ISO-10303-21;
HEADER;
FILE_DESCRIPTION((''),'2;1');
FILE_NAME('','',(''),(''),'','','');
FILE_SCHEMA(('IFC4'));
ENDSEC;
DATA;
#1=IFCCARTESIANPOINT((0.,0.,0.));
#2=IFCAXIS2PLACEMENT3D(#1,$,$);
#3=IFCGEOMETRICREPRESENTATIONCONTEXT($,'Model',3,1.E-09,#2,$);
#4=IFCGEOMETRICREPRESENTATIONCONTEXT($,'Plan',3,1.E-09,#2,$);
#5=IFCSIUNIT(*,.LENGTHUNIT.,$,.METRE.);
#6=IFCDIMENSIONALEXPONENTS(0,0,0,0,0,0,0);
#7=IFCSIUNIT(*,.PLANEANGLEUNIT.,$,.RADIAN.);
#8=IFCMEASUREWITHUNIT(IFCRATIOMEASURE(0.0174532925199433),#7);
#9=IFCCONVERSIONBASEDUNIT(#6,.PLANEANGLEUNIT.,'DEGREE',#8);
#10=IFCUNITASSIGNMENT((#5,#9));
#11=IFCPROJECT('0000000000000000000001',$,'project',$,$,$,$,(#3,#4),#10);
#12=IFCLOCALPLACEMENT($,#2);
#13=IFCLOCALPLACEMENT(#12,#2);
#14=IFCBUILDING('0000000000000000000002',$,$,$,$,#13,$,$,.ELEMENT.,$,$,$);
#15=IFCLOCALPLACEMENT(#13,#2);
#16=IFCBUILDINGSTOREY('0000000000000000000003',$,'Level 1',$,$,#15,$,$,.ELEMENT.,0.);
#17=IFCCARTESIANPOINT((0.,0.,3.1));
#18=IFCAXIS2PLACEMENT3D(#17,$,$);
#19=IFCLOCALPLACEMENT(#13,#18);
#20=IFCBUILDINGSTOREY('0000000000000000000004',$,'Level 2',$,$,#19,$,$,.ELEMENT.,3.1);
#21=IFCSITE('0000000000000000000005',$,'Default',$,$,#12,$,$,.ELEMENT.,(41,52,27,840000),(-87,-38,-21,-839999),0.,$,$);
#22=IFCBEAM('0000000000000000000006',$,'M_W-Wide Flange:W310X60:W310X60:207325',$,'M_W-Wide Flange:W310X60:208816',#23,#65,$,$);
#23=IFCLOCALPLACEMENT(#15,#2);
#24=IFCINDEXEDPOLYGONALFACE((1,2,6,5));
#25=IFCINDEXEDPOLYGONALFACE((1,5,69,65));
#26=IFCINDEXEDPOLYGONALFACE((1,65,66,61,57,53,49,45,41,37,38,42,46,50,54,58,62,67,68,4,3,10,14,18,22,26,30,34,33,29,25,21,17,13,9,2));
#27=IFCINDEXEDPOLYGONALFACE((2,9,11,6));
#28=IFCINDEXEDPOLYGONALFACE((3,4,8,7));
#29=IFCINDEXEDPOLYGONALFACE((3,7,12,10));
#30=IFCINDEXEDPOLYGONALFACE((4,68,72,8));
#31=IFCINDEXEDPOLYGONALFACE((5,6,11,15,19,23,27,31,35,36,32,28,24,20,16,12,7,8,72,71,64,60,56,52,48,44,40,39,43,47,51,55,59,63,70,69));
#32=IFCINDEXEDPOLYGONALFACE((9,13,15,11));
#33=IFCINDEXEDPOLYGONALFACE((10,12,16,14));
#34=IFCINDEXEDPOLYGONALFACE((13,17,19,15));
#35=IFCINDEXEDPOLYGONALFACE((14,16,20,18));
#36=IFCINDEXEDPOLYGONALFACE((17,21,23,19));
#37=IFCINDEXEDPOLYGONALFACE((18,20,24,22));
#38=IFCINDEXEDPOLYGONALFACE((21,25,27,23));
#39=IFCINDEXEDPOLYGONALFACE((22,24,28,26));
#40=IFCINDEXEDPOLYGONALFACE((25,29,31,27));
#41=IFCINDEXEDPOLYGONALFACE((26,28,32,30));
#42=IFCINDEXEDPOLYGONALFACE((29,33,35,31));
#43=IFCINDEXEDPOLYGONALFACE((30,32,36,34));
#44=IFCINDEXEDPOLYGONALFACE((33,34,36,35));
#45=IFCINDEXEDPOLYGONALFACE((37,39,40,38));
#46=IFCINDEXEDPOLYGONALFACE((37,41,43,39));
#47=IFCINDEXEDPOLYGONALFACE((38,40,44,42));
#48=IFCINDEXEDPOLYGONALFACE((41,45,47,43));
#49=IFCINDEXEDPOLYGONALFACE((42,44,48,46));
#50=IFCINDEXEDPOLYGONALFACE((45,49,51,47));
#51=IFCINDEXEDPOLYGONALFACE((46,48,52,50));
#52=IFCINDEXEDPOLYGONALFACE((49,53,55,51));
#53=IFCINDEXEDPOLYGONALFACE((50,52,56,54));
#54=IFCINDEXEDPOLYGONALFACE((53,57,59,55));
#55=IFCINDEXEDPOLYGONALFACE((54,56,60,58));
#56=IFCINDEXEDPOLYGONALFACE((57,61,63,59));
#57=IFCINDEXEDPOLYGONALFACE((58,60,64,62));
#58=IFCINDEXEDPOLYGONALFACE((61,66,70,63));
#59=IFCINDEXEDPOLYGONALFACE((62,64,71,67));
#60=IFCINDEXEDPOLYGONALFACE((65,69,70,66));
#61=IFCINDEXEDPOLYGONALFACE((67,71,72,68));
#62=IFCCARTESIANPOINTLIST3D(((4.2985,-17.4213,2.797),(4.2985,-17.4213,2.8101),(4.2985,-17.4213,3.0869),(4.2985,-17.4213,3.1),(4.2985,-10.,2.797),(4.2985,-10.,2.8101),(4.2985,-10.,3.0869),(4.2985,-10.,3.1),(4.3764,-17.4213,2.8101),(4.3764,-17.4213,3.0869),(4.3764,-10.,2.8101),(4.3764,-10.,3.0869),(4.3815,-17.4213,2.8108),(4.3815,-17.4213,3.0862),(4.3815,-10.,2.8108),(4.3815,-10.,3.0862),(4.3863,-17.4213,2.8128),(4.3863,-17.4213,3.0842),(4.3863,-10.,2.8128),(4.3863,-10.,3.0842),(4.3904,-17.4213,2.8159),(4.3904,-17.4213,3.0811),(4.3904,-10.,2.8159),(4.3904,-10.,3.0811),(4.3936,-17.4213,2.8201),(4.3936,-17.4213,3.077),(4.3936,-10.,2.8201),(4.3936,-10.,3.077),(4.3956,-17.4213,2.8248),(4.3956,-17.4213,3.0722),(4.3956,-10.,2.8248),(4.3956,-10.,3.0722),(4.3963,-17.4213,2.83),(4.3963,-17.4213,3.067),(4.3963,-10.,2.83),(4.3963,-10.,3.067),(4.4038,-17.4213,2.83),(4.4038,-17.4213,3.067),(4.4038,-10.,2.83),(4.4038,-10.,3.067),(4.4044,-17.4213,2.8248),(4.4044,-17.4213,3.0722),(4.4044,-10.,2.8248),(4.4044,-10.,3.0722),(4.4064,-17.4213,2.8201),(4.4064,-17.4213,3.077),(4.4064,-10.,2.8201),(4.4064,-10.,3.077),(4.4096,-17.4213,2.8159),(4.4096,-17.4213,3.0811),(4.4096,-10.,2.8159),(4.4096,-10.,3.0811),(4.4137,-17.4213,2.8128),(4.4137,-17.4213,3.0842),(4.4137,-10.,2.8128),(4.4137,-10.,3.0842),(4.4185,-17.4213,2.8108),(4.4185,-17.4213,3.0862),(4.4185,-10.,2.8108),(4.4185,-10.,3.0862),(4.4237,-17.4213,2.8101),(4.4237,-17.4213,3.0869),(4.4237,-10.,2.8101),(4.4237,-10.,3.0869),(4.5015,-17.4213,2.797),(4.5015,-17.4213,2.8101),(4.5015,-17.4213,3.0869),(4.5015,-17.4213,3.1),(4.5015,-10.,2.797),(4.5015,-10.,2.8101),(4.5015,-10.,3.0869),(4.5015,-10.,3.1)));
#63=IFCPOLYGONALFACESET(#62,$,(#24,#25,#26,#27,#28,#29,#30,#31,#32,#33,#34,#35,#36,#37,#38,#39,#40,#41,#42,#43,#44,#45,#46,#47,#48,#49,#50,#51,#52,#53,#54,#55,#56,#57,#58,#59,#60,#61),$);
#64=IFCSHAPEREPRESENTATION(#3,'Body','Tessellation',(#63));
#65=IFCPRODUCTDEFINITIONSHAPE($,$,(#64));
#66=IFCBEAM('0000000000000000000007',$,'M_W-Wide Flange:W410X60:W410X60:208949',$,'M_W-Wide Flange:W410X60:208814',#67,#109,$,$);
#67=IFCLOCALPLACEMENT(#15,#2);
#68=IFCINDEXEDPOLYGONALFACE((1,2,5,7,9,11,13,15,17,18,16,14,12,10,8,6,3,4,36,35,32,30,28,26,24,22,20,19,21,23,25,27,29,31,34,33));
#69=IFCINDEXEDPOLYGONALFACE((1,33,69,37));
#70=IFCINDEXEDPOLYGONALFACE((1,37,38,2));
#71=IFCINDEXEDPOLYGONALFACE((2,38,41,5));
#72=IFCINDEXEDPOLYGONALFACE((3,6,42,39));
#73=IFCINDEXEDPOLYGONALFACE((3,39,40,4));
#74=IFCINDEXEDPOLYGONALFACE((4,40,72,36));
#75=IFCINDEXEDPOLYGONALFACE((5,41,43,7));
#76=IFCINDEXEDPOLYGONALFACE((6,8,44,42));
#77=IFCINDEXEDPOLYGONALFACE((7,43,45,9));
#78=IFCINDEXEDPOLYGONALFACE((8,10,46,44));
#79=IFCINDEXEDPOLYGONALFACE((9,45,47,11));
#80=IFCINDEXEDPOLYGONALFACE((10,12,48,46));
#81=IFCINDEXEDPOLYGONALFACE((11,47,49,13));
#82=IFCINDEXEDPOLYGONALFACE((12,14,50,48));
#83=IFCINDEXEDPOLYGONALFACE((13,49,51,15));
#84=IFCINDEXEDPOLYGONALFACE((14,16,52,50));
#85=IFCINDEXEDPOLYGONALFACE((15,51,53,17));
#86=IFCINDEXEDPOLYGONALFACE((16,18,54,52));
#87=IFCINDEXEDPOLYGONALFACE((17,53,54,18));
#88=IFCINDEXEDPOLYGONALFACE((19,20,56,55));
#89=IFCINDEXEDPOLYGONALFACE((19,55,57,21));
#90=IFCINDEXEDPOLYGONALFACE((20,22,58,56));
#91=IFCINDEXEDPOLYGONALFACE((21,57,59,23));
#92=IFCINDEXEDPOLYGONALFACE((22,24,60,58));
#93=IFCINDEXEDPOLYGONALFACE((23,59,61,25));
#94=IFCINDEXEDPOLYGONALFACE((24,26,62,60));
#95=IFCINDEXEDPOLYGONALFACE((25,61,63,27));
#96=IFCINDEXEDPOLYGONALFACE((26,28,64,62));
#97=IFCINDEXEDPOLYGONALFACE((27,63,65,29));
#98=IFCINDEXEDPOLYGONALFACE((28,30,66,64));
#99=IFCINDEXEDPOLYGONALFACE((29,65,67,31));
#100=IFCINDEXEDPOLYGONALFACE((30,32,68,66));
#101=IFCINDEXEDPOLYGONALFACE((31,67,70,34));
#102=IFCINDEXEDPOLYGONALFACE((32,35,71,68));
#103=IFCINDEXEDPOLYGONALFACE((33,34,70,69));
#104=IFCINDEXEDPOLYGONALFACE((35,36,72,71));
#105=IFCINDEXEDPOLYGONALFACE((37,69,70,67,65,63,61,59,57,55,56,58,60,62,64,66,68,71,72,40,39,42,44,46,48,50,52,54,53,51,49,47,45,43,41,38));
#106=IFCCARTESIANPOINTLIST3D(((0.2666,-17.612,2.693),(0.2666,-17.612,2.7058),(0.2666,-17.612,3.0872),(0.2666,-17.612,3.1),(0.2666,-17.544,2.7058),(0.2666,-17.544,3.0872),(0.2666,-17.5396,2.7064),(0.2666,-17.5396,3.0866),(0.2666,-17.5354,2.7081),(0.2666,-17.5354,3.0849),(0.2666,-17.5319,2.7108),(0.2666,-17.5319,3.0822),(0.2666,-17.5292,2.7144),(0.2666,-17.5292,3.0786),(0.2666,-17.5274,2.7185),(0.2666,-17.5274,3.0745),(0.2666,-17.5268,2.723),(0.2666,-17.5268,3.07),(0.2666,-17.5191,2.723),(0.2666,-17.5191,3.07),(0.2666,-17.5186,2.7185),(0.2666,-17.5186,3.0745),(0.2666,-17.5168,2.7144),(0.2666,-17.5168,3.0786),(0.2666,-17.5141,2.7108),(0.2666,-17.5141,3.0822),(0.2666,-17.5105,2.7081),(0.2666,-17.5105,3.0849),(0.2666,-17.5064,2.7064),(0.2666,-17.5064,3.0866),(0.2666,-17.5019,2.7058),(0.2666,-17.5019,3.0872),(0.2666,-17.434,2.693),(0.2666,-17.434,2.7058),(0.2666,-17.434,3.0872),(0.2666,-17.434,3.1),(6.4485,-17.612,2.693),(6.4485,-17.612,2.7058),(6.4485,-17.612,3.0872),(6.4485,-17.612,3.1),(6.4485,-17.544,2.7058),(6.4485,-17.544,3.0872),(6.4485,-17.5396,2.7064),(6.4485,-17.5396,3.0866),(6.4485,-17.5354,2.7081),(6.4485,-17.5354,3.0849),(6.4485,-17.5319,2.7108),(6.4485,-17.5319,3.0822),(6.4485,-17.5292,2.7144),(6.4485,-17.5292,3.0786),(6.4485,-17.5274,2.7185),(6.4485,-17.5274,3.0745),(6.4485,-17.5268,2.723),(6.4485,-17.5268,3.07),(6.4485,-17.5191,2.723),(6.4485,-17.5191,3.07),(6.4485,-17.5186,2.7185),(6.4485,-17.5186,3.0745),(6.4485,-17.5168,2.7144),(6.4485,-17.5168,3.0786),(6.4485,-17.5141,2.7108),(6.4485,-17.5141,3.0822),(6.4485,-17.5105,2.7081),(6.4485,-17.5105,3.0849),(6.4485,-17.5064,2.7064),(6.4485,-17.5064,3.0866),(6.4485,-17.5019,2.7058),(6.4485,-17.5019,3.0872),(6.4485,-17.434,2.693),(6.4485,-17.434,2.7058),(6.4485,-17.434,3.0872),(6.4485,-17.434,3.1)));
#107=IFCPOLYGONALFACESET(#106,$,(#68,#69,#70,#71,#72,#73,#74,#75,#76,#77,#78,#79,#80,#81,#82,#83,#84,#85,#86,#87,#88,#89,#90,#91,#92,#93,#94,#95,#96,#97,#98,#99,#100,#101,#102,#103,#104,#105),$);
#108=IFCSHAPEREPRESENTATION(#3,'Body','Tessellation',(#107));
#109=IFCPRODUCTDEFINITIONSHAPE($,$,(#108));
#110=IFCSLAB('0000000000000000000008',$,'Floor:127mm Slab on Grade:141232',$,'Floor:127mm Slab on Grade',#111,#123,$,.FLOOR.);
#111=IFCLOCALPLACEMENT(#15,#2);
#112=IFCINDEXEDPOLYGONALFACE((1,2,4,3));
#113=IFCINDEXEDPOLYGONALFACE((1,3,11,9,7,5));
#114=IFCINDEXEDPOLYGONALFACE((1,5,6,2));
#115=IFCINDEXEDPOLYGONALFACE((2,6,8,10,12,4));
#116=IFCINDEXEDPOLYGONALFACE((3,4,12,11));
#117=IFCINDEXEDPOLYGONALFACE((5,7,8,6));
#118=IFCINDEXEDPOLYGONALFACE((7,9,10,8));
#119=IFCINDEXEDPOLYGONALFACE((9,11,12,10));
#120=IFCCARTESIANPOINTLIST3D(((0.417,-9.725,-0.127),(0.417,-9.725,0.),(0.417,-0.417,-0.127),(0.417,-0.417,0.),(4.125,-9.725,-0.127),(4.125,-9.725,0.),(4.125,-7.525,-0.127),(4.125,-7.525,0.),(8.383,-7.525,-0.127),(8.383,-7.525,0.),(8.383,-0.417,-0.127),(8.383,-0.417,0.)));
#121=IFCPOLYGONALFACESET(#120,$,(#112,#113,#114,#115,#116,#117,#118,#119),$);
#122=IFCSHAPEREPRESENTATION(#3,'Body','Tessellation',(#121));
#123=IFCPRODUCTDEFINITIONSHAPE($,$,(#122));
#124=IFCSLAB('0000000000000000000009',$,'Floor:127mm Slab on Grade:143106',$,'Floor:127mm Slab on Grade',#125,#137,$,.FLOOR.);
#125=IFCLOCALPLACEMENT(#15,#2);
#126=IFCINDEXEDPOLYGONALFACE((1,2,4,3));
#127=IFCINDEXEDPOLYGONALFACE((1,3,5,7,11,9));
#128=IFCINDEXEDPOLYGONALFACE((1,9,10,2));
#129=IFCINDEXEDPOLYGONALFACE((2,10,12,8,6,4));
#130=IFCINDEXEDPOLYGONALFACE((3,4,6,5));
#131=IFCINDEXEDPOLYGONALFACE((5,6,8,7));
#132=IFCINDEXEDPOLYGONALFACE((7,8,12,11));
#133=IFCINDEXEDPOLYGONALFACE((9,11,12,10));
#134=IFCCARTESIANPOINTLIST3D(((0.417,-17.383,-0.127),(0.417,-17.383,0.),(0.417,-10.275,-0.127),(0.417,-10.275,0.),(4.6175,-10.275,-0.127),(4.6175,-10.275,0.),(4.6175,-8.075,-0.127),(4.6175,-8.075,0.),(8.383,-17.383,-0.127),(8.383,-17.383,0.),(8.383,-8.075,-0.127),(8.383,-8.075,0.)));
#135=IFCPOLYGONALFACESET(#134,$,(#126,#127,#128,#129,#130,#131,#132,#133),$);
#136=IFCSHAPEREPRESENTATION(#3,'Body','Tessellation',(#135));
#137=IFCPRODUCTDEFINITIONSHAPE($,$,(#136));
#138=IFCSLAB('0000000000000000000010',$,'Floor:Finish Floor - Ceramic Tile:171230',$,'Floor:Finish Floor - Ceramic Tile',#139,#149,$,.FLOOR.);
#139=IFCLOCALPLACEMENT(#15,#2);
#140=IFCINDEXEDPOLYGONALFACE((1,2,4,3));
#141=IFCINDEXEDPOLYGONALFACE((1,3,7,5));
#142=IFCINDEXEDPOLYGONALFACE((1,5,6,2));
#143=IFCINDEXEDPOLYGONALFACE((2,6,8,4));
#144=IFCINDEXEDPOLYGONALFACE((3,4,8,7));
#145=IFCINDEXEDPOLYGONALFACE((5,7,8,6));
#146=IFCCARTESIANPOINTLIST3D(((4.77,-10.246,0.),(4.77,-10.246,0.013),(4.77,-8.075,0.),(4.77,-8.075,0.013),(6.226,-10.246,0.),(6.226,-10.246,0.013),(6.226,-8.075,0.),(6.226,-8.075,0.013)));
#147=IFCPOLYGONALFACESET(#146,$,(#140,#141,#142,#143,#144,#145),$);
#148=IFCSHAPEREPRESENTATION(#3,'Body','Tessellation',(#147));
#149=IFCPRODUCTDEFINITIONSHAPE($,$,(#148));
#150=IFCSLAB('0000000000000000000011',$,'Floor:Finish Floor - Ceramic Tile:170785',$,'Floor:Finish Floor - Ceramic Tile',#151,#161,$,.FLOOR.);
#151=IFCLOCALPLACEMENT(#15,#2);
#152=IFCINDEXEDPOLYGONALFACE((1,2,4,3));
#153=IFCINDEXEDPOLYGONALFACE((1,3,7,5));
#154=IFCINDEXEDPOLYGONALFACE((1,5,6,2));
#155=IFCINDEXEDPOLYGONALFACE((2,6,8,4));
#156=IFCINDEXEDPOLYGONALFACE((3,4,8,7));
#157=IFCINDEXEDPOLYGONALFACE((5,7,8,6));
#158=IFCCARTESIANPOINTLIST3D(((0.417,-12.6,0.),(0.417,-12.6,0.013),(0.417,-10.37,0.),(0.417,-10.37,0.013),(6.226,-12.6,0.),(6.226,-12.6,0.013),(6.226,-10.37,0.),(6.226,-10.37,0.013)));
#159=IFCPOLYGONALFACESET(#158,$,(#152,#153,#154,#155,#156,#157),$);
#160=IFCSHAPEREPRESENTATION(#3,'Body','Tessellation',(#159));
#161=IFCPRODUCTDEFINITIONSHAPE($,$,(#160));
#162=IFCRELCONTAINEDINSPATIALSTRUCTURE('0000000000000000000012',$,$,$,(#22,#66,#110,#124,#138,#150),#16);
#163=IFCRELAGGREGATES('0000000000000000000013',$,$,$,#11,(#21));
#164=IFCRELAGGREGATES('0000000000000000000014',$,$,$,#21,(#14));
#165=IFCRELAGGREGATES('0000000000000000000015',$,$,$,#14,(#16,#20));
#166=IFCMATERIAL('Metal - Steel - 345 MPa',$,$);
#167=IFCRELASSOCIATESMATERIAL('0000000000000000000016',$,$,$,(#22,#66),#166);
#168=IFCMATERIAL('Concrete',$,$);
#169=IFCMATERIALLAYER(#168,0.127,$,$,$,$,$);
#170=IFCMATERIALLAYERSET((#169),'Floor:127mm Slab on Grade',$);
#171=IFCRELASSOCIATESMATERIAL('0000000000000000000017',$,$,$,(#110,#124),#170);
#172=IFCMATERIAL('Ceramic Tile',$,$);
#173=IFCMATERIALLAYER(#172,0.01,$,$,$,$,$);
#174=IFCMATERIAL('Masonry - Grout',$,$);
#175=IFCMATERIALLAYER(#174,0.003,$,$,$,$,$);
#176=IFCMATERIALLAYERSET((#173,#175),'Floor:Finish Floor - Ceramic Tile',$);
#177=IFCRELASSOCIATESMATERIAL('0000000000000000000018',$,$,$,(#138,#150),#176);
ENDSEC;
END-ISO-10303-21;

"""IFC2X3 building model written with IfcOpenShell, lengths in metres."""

from ifc_helpers import new_model, entity, si_unit, converted_unit, frame, frame_2d, origin, place, context, project, spatial, polyline, circle_curve, parameter, trimmed, segment, composite_curve, rectangle, outline, extrude, material, layer, layer_set, layer_usage, element, save


model = new_model("IFC2X3")

# Units and contexts
model_context = context("Model", 3, precision=1e-09, world=origin())
plan_context = context("Plan", 3, precision=1e-09, world=origin())
ifc_project = project(units=[si_unit("LENGTHUNIT", "METRE"), converted_unit("PLANEANGLEUNIT", "DEGREE", entity("IfcRatioMeasure", 0.0174532925199433), si_unit("PLANEANGLEUNIT", "RADIAN"), dimensions=[0, 0, 0, 0, 0, 0, 0])], contexts=[model_context, plan_context])

# Site, building, storey
site_placement = place(None, origin())
site = spatial("IfcSite", under=ifc_project, at=site_placement, Name="Default", CompositionType="ELEMENT", RefLatitude=(41, 52, 27, 840000), RefLongitude=(-87, -38, -21, -839999), RefElevation=0.0)
building_placement = place(site_placement, origin())
building = spatial("IfcBuilding", under=site, at=building_placement, CompositionType="ELEMENT")
storey_1_placement = place(building_placement, origin())
storey_1 = spatial("IfcBuildingStorey", under=building, at=storey_1_placement, Name="Level 1", CompositionType="ELEMENT", Elevation=0.0)

# Beams
ifc_material_1 = material(Name="Metal - Steel - 345 MPa")
beam_1_placement = place(storey_1_placement, frame((4.4, -10.0, 3.1), z_axis=(0.0, 0.0, 1.0), x_axis=(-1.0, 0.0, 0.0)))
element("IfcBeam", 1, at=beam_1_placement, inside=storey_1, material=ifc_material_1, Name="M_W-Wide Flange:W310X60:W310X60:207325", ObjectType="M_W-Wide Flange:W310X60:208816", context=model_context, shape_type="SweptSolid", body=[
    extrude(outline(composite_curve([segment(polyline([(0.1384, -0.1015), (0.1515, -0.1015)]), True, "CONTINUOUS"), segment(polyline([(0.1515, -0.1015), (0.1515, 0.1015)]), True, "CONTINUOUS"), segment(polyline([(0.1515, 0.1015), (0.1384, 0.1015)]), True, "CONTINUOUS"), segment(polyline([(0.1384, 0.1015), (0.1384, 0.0236)]), True, "CONTINUOUS"), segment(trimmed(circle_curve(frame_2d((0.1185, 0.0236), x_axis=(0.0, 1.0)), 0.0199), [parameter(180.0)], [parameter(270.0)], True, "PARAMETER"), False, "CONTINUOUS"), segment(polyline([(0.1185, 0.0037), (-0.1185, 0.0037)]), True, "CONTINUOUS"), segment(trimmed(circle_curve(frame_2d((-0.1185, 0.0236), x_axis=(0.0, 1.0)), 0.0199), [parameter(90.0)], [parameter(180.0)], True, "PARAMETER"), False, "CONTINUOUS"), segment(polyline([(-0.1384, 0.0236), (-0.1384, 0.1015)]), True, "CONTINUOUS"), segment(polyline([(-0.1384, 0.1015), (-0.1515, 0.1015)]), True, "CONTINUOUS"), segment(polyline([(-0.1515, 0.1015), (-0.1515, -0.1015)]), True, "CONTINUOUS"), segment(polyline([(-0.1515, -0.1015), (-0.1384, -0.1015)]), True, "CONTINUOUS"), segment(polyline([(-0.1384, -0.1015), (-0.1384, -0.0237)]), True, "CONTINUOUS"), segment(trimmed(circle_curve(frame_2d((-0.1185, -0.0237), x_axis=(0.0, 1.0)), 0.0199), [parameter(360.0)], [parameter(90.0)], True, "PARAMETER"), False, "CONTINUOUS"), segment(polyline([(-0.1185, -0.0038), (0.1185, -0.0038)]), True, "CONTINUOUS"), segment(trimmed(circle_curve(frame_2d((0.1185, -0.0237), x_axis=(0.0, 1.0)), 0.0199), [parameter(270.0)], [parameter(0.0)], True, "PARAMETER"), False, "CONTINUOUS"), segment(polyline([(0.1384, -0.0237), (0.1384, -0.1015)]), True, "CONTINUOUS")], self_intersect=False)), frame((0.0, 7.4213, -0.1515), z_axis=(0.0, -1.0, 0.0), x_axis=(0.0, 0.0, -1.0)), (0.0, 0.0, 1.0), 7.4213),
])
beam_2_placement = place(storey_1_placement, frame((0.2085, -17.523, 3.1), z_axis=(0.0, 0.0, 1.0), x_axis=(0.0, -1.0, 0.0)))
element("IfcBeam", 2, at=beam_2_placement, inside=storey_1, material=ifc_material_1, Name="M_W-Wide Flange:W410X60:W410X60:208949", ObjectType="M_W-Wide Flange:W410X60:208814", context=model_context, shape_type="SweptSolid", body=[
    extrude(outline(composite_curve([segment(polyline([(-0.089, -0.1907), (-0.089, -0.2035)]), True, "CONTINUOUS"), segment(polyline([(-0.089, -0.2035), (0.089, -0.2035)]), True, "CONTINUOUS"), segment(polyline([(0.089, -0.2035), (0.089, -0.1907)]), True, "CONTINUOUS"), segment(polyline([(0.089, -0.1907), (0.021, -0.1907)]), True, "CONTINUOUS"), segment(trimmed(circle_curve(frame_2d((0.021, -0.1735), x_axis=(0.0, -1.0)), 0.0172), [parameter(270.0)], [parameter(360.0)], True, "PARAMETER"), False, "CONTINUOUS"), segment(polyline([(0.0038, -0.1735), (0.0038, 0.1735)]), True, "CONTINUOUS"), segment(trimmed(circle_curve(frame_2d((0.021, 0.1735), x_axis=(-1.0, 0.0)), 0.0172), [parameter(270.0)], [parameter(360.0)], True, "PARAMETER"), False, "CONTINUOUS"), segment(polyline([(0.021, 0.1907), (0.089, 0.1907)]), True, "CONTINUOUS"), segment(polyline([(0.089, 0.1907), (0.089, 0.2035)]), True, "CONTINUOUS"), segment(polyline([(0.089, 0.2035), (-0.089, 0.2035)]), True, "CONTINUOUS"), segment(polyline([(-0.089, 0.2035), (-0.089, 0.1907)]), True, "CONTINUOUS"), segment(polyline([(-0.089, 0.1907), (-0.0211, 0.1907)]), True, "CONTINUOUS"), segment(trimmed(circle_curve(frame_2d((-0.0211, 0.1735), x_axis=(0.0, 1.0)), 0.0172), [parameter(270.0)], [parameter(0.0)], True, "PARAMETER"), False, "CONTINUOUS"), segment(polyline([(-0.0039, 0.1735), (-0.0039, -0.1735)]), True, "CONTINUOUS"), segment(trimmed(circle_curve(frame_2d((-0.0211, -0.1735), x_axis=(1.0, 0.0)), 0.0172), [parameter(270.0)], [parameter(0.0)], True, "PARAMETER"), False, "CONTINUOUS"), segment(polyline([(-0.0211, -0.1907), (-0.089, -0.1907)]), True, "CONTINUOUS")], self_intersect=False)), frame((0.0, 0.0581, -0.2035), z_axis=(0.0, -1.0, 0.0), x_axis=(1.0, 0.0, 0.0)), (0.0, 0.0, -1.0), 6.1819),
])

# Slabs
ifc_material_2 = material(Name="Concrete")
ifc_layer_1 = layer(ifc_material_2, 0.127)
ifc_layer_set_1 = layer_set([ifc_layer_1], Name="Floor:127mm Slab on Grade")
ifc_layer_usage_1 = layer_usage(ifc_layer_set_1, "AXIS3", "POSITIVE", 0.0)
slab_1_placement = place(storey_1_placement, frame((0.417, -9.725, -0.127)))
element("IfcSlab", 3, at=slab_1_placement, inside=storey_1, material=ifc_layer_usage_1, Name="Floor:127mm Slab on Grade:141232", ObjectType="Floor:127mm Slab on Grade", PredefinedType="FLOOR", context=model_context, shape_type="SweptSolid", body=[
    extrude(outline(polyline([(-3.983, 4.654), (-3.983, -2.454), (0.275, -2.454), (0.275, -4.654), (3.983, -4.654), (3.983, 4.654), (-3.983, 4.654)])), frame((3.983, 4.654, 0.127), z_axis=(0.0, 0.0, -1.0), x_axis=(-1.0, 0.0, 0.0)), (0.0, 0.0, 1.0), 0.127),
])
slab_2_placement = place(storey_1_placement, frame((0.417, -17.383, -0.127)))
element("IfcSlab", 4, at=slab_2_placement, inside=storey_1, material=ifc_layer_usage_1, Name="Floor:127mm Slab on Grade:143106", ObjectType="Floor:127mm Slab on Grade", PredefinedType="FLOOR", context=model_context, shape_type="SweptSolid", body=[
    extrude(outline(polyline([(-3.983, 4.654), (-3.983, -4.654), (3.983, -4.654), (3.983, 2.454), (-0.2175, 2.454), (-0.2175, 4.654), (-3.983, 4.654)])), frame((3.983, 4.654, 0.127), z_axis=(0.0, 0.0, -1.0), x_axis=(-1.0, 0.0, 0.0)), (0.0, 0.0, 1.0), 0.127),
])
ifc_material_3 = material(Name="Ceramic Tile")
ifc_layer_2 = layer(ifc_material_3, 0.01)
ifc_material_4 = material(Name="Masonry - Grout")
ifc_layer_3 = layer(ifc_material_4, 0.003)
ifc_layer_set_2 = layer_set([ifc_layer_2, ifc_layer_3], Name="Floor:Finish Floor - Ceramic Tile")
ifc_layer_usage_2 = layer_usage(ifc_layer_set_2, "AXIS3", "POSITIVE", 0.0)
slab_3_placement = place(storey_1_placement, frame((4.77, -10.246, 0.0)))
element("IfcSlab", 5, at=slab_3_placement, inside=storey_1, material=ifc_layer_usage_2, Name="Floor:Finish Floor - Ceramic Tile:171230", ObjectType="Floor:Finish Floor - Ceramic Tile", PredefinedType="FLOOR", context=model_context, shape_type="SweptSolid", body=[
    extrude(rectangle(XDim=1.456, YDim=2.171, at=frame_2d((0.0, 0.0), x_axis=(-1.0, 0.0))), frame((0.728, 1.0855, 0.013), z_axis=(0.0, 0.0, -1.0), x_axis=(-1.0, 0.0, 0.0)), (0.0, 0.0, 1.0), 0.013),
])
slab_4_placement = place(storey_1_placement, frame((0.417, -12.6, 0.0)))
element("IfcSlab", 6, at=slab_4_placement, inside=storey_1, material=ifc_layer_usage_2, Name="Floor:Finish Floor - Ceramic Tile:170785", ObjectType="Floor:Finish Floor - Ceramic Tile", PredefinedType="FLOOR", context=model_context, shape_type="SweptSolid", body=[
    extrude(rectangle(XDim=5.809, YDim=2.23, at=frame_2d((0.0, 0.0), x_axis=(-1.0, 0.0))), frame((2.9045, 1.115, 0.013), z_axis=(0.0, 0.0, -1.0), x_axis=(-1.0, 0.0, 0.0)), (0.0, 0.0, 1.0), 0.013),
])

# Shared definitions
storey_2_placement = place(building_placement, frame((0.0, 0.0, 3.1)))
storey_2 = spatial("IfcBuildingStorey", under=building, at=storey_2_placement, Name="Level 2", CompositionType="ELEMENT", Elevation=3.1)

save(model, "model.ifc")
